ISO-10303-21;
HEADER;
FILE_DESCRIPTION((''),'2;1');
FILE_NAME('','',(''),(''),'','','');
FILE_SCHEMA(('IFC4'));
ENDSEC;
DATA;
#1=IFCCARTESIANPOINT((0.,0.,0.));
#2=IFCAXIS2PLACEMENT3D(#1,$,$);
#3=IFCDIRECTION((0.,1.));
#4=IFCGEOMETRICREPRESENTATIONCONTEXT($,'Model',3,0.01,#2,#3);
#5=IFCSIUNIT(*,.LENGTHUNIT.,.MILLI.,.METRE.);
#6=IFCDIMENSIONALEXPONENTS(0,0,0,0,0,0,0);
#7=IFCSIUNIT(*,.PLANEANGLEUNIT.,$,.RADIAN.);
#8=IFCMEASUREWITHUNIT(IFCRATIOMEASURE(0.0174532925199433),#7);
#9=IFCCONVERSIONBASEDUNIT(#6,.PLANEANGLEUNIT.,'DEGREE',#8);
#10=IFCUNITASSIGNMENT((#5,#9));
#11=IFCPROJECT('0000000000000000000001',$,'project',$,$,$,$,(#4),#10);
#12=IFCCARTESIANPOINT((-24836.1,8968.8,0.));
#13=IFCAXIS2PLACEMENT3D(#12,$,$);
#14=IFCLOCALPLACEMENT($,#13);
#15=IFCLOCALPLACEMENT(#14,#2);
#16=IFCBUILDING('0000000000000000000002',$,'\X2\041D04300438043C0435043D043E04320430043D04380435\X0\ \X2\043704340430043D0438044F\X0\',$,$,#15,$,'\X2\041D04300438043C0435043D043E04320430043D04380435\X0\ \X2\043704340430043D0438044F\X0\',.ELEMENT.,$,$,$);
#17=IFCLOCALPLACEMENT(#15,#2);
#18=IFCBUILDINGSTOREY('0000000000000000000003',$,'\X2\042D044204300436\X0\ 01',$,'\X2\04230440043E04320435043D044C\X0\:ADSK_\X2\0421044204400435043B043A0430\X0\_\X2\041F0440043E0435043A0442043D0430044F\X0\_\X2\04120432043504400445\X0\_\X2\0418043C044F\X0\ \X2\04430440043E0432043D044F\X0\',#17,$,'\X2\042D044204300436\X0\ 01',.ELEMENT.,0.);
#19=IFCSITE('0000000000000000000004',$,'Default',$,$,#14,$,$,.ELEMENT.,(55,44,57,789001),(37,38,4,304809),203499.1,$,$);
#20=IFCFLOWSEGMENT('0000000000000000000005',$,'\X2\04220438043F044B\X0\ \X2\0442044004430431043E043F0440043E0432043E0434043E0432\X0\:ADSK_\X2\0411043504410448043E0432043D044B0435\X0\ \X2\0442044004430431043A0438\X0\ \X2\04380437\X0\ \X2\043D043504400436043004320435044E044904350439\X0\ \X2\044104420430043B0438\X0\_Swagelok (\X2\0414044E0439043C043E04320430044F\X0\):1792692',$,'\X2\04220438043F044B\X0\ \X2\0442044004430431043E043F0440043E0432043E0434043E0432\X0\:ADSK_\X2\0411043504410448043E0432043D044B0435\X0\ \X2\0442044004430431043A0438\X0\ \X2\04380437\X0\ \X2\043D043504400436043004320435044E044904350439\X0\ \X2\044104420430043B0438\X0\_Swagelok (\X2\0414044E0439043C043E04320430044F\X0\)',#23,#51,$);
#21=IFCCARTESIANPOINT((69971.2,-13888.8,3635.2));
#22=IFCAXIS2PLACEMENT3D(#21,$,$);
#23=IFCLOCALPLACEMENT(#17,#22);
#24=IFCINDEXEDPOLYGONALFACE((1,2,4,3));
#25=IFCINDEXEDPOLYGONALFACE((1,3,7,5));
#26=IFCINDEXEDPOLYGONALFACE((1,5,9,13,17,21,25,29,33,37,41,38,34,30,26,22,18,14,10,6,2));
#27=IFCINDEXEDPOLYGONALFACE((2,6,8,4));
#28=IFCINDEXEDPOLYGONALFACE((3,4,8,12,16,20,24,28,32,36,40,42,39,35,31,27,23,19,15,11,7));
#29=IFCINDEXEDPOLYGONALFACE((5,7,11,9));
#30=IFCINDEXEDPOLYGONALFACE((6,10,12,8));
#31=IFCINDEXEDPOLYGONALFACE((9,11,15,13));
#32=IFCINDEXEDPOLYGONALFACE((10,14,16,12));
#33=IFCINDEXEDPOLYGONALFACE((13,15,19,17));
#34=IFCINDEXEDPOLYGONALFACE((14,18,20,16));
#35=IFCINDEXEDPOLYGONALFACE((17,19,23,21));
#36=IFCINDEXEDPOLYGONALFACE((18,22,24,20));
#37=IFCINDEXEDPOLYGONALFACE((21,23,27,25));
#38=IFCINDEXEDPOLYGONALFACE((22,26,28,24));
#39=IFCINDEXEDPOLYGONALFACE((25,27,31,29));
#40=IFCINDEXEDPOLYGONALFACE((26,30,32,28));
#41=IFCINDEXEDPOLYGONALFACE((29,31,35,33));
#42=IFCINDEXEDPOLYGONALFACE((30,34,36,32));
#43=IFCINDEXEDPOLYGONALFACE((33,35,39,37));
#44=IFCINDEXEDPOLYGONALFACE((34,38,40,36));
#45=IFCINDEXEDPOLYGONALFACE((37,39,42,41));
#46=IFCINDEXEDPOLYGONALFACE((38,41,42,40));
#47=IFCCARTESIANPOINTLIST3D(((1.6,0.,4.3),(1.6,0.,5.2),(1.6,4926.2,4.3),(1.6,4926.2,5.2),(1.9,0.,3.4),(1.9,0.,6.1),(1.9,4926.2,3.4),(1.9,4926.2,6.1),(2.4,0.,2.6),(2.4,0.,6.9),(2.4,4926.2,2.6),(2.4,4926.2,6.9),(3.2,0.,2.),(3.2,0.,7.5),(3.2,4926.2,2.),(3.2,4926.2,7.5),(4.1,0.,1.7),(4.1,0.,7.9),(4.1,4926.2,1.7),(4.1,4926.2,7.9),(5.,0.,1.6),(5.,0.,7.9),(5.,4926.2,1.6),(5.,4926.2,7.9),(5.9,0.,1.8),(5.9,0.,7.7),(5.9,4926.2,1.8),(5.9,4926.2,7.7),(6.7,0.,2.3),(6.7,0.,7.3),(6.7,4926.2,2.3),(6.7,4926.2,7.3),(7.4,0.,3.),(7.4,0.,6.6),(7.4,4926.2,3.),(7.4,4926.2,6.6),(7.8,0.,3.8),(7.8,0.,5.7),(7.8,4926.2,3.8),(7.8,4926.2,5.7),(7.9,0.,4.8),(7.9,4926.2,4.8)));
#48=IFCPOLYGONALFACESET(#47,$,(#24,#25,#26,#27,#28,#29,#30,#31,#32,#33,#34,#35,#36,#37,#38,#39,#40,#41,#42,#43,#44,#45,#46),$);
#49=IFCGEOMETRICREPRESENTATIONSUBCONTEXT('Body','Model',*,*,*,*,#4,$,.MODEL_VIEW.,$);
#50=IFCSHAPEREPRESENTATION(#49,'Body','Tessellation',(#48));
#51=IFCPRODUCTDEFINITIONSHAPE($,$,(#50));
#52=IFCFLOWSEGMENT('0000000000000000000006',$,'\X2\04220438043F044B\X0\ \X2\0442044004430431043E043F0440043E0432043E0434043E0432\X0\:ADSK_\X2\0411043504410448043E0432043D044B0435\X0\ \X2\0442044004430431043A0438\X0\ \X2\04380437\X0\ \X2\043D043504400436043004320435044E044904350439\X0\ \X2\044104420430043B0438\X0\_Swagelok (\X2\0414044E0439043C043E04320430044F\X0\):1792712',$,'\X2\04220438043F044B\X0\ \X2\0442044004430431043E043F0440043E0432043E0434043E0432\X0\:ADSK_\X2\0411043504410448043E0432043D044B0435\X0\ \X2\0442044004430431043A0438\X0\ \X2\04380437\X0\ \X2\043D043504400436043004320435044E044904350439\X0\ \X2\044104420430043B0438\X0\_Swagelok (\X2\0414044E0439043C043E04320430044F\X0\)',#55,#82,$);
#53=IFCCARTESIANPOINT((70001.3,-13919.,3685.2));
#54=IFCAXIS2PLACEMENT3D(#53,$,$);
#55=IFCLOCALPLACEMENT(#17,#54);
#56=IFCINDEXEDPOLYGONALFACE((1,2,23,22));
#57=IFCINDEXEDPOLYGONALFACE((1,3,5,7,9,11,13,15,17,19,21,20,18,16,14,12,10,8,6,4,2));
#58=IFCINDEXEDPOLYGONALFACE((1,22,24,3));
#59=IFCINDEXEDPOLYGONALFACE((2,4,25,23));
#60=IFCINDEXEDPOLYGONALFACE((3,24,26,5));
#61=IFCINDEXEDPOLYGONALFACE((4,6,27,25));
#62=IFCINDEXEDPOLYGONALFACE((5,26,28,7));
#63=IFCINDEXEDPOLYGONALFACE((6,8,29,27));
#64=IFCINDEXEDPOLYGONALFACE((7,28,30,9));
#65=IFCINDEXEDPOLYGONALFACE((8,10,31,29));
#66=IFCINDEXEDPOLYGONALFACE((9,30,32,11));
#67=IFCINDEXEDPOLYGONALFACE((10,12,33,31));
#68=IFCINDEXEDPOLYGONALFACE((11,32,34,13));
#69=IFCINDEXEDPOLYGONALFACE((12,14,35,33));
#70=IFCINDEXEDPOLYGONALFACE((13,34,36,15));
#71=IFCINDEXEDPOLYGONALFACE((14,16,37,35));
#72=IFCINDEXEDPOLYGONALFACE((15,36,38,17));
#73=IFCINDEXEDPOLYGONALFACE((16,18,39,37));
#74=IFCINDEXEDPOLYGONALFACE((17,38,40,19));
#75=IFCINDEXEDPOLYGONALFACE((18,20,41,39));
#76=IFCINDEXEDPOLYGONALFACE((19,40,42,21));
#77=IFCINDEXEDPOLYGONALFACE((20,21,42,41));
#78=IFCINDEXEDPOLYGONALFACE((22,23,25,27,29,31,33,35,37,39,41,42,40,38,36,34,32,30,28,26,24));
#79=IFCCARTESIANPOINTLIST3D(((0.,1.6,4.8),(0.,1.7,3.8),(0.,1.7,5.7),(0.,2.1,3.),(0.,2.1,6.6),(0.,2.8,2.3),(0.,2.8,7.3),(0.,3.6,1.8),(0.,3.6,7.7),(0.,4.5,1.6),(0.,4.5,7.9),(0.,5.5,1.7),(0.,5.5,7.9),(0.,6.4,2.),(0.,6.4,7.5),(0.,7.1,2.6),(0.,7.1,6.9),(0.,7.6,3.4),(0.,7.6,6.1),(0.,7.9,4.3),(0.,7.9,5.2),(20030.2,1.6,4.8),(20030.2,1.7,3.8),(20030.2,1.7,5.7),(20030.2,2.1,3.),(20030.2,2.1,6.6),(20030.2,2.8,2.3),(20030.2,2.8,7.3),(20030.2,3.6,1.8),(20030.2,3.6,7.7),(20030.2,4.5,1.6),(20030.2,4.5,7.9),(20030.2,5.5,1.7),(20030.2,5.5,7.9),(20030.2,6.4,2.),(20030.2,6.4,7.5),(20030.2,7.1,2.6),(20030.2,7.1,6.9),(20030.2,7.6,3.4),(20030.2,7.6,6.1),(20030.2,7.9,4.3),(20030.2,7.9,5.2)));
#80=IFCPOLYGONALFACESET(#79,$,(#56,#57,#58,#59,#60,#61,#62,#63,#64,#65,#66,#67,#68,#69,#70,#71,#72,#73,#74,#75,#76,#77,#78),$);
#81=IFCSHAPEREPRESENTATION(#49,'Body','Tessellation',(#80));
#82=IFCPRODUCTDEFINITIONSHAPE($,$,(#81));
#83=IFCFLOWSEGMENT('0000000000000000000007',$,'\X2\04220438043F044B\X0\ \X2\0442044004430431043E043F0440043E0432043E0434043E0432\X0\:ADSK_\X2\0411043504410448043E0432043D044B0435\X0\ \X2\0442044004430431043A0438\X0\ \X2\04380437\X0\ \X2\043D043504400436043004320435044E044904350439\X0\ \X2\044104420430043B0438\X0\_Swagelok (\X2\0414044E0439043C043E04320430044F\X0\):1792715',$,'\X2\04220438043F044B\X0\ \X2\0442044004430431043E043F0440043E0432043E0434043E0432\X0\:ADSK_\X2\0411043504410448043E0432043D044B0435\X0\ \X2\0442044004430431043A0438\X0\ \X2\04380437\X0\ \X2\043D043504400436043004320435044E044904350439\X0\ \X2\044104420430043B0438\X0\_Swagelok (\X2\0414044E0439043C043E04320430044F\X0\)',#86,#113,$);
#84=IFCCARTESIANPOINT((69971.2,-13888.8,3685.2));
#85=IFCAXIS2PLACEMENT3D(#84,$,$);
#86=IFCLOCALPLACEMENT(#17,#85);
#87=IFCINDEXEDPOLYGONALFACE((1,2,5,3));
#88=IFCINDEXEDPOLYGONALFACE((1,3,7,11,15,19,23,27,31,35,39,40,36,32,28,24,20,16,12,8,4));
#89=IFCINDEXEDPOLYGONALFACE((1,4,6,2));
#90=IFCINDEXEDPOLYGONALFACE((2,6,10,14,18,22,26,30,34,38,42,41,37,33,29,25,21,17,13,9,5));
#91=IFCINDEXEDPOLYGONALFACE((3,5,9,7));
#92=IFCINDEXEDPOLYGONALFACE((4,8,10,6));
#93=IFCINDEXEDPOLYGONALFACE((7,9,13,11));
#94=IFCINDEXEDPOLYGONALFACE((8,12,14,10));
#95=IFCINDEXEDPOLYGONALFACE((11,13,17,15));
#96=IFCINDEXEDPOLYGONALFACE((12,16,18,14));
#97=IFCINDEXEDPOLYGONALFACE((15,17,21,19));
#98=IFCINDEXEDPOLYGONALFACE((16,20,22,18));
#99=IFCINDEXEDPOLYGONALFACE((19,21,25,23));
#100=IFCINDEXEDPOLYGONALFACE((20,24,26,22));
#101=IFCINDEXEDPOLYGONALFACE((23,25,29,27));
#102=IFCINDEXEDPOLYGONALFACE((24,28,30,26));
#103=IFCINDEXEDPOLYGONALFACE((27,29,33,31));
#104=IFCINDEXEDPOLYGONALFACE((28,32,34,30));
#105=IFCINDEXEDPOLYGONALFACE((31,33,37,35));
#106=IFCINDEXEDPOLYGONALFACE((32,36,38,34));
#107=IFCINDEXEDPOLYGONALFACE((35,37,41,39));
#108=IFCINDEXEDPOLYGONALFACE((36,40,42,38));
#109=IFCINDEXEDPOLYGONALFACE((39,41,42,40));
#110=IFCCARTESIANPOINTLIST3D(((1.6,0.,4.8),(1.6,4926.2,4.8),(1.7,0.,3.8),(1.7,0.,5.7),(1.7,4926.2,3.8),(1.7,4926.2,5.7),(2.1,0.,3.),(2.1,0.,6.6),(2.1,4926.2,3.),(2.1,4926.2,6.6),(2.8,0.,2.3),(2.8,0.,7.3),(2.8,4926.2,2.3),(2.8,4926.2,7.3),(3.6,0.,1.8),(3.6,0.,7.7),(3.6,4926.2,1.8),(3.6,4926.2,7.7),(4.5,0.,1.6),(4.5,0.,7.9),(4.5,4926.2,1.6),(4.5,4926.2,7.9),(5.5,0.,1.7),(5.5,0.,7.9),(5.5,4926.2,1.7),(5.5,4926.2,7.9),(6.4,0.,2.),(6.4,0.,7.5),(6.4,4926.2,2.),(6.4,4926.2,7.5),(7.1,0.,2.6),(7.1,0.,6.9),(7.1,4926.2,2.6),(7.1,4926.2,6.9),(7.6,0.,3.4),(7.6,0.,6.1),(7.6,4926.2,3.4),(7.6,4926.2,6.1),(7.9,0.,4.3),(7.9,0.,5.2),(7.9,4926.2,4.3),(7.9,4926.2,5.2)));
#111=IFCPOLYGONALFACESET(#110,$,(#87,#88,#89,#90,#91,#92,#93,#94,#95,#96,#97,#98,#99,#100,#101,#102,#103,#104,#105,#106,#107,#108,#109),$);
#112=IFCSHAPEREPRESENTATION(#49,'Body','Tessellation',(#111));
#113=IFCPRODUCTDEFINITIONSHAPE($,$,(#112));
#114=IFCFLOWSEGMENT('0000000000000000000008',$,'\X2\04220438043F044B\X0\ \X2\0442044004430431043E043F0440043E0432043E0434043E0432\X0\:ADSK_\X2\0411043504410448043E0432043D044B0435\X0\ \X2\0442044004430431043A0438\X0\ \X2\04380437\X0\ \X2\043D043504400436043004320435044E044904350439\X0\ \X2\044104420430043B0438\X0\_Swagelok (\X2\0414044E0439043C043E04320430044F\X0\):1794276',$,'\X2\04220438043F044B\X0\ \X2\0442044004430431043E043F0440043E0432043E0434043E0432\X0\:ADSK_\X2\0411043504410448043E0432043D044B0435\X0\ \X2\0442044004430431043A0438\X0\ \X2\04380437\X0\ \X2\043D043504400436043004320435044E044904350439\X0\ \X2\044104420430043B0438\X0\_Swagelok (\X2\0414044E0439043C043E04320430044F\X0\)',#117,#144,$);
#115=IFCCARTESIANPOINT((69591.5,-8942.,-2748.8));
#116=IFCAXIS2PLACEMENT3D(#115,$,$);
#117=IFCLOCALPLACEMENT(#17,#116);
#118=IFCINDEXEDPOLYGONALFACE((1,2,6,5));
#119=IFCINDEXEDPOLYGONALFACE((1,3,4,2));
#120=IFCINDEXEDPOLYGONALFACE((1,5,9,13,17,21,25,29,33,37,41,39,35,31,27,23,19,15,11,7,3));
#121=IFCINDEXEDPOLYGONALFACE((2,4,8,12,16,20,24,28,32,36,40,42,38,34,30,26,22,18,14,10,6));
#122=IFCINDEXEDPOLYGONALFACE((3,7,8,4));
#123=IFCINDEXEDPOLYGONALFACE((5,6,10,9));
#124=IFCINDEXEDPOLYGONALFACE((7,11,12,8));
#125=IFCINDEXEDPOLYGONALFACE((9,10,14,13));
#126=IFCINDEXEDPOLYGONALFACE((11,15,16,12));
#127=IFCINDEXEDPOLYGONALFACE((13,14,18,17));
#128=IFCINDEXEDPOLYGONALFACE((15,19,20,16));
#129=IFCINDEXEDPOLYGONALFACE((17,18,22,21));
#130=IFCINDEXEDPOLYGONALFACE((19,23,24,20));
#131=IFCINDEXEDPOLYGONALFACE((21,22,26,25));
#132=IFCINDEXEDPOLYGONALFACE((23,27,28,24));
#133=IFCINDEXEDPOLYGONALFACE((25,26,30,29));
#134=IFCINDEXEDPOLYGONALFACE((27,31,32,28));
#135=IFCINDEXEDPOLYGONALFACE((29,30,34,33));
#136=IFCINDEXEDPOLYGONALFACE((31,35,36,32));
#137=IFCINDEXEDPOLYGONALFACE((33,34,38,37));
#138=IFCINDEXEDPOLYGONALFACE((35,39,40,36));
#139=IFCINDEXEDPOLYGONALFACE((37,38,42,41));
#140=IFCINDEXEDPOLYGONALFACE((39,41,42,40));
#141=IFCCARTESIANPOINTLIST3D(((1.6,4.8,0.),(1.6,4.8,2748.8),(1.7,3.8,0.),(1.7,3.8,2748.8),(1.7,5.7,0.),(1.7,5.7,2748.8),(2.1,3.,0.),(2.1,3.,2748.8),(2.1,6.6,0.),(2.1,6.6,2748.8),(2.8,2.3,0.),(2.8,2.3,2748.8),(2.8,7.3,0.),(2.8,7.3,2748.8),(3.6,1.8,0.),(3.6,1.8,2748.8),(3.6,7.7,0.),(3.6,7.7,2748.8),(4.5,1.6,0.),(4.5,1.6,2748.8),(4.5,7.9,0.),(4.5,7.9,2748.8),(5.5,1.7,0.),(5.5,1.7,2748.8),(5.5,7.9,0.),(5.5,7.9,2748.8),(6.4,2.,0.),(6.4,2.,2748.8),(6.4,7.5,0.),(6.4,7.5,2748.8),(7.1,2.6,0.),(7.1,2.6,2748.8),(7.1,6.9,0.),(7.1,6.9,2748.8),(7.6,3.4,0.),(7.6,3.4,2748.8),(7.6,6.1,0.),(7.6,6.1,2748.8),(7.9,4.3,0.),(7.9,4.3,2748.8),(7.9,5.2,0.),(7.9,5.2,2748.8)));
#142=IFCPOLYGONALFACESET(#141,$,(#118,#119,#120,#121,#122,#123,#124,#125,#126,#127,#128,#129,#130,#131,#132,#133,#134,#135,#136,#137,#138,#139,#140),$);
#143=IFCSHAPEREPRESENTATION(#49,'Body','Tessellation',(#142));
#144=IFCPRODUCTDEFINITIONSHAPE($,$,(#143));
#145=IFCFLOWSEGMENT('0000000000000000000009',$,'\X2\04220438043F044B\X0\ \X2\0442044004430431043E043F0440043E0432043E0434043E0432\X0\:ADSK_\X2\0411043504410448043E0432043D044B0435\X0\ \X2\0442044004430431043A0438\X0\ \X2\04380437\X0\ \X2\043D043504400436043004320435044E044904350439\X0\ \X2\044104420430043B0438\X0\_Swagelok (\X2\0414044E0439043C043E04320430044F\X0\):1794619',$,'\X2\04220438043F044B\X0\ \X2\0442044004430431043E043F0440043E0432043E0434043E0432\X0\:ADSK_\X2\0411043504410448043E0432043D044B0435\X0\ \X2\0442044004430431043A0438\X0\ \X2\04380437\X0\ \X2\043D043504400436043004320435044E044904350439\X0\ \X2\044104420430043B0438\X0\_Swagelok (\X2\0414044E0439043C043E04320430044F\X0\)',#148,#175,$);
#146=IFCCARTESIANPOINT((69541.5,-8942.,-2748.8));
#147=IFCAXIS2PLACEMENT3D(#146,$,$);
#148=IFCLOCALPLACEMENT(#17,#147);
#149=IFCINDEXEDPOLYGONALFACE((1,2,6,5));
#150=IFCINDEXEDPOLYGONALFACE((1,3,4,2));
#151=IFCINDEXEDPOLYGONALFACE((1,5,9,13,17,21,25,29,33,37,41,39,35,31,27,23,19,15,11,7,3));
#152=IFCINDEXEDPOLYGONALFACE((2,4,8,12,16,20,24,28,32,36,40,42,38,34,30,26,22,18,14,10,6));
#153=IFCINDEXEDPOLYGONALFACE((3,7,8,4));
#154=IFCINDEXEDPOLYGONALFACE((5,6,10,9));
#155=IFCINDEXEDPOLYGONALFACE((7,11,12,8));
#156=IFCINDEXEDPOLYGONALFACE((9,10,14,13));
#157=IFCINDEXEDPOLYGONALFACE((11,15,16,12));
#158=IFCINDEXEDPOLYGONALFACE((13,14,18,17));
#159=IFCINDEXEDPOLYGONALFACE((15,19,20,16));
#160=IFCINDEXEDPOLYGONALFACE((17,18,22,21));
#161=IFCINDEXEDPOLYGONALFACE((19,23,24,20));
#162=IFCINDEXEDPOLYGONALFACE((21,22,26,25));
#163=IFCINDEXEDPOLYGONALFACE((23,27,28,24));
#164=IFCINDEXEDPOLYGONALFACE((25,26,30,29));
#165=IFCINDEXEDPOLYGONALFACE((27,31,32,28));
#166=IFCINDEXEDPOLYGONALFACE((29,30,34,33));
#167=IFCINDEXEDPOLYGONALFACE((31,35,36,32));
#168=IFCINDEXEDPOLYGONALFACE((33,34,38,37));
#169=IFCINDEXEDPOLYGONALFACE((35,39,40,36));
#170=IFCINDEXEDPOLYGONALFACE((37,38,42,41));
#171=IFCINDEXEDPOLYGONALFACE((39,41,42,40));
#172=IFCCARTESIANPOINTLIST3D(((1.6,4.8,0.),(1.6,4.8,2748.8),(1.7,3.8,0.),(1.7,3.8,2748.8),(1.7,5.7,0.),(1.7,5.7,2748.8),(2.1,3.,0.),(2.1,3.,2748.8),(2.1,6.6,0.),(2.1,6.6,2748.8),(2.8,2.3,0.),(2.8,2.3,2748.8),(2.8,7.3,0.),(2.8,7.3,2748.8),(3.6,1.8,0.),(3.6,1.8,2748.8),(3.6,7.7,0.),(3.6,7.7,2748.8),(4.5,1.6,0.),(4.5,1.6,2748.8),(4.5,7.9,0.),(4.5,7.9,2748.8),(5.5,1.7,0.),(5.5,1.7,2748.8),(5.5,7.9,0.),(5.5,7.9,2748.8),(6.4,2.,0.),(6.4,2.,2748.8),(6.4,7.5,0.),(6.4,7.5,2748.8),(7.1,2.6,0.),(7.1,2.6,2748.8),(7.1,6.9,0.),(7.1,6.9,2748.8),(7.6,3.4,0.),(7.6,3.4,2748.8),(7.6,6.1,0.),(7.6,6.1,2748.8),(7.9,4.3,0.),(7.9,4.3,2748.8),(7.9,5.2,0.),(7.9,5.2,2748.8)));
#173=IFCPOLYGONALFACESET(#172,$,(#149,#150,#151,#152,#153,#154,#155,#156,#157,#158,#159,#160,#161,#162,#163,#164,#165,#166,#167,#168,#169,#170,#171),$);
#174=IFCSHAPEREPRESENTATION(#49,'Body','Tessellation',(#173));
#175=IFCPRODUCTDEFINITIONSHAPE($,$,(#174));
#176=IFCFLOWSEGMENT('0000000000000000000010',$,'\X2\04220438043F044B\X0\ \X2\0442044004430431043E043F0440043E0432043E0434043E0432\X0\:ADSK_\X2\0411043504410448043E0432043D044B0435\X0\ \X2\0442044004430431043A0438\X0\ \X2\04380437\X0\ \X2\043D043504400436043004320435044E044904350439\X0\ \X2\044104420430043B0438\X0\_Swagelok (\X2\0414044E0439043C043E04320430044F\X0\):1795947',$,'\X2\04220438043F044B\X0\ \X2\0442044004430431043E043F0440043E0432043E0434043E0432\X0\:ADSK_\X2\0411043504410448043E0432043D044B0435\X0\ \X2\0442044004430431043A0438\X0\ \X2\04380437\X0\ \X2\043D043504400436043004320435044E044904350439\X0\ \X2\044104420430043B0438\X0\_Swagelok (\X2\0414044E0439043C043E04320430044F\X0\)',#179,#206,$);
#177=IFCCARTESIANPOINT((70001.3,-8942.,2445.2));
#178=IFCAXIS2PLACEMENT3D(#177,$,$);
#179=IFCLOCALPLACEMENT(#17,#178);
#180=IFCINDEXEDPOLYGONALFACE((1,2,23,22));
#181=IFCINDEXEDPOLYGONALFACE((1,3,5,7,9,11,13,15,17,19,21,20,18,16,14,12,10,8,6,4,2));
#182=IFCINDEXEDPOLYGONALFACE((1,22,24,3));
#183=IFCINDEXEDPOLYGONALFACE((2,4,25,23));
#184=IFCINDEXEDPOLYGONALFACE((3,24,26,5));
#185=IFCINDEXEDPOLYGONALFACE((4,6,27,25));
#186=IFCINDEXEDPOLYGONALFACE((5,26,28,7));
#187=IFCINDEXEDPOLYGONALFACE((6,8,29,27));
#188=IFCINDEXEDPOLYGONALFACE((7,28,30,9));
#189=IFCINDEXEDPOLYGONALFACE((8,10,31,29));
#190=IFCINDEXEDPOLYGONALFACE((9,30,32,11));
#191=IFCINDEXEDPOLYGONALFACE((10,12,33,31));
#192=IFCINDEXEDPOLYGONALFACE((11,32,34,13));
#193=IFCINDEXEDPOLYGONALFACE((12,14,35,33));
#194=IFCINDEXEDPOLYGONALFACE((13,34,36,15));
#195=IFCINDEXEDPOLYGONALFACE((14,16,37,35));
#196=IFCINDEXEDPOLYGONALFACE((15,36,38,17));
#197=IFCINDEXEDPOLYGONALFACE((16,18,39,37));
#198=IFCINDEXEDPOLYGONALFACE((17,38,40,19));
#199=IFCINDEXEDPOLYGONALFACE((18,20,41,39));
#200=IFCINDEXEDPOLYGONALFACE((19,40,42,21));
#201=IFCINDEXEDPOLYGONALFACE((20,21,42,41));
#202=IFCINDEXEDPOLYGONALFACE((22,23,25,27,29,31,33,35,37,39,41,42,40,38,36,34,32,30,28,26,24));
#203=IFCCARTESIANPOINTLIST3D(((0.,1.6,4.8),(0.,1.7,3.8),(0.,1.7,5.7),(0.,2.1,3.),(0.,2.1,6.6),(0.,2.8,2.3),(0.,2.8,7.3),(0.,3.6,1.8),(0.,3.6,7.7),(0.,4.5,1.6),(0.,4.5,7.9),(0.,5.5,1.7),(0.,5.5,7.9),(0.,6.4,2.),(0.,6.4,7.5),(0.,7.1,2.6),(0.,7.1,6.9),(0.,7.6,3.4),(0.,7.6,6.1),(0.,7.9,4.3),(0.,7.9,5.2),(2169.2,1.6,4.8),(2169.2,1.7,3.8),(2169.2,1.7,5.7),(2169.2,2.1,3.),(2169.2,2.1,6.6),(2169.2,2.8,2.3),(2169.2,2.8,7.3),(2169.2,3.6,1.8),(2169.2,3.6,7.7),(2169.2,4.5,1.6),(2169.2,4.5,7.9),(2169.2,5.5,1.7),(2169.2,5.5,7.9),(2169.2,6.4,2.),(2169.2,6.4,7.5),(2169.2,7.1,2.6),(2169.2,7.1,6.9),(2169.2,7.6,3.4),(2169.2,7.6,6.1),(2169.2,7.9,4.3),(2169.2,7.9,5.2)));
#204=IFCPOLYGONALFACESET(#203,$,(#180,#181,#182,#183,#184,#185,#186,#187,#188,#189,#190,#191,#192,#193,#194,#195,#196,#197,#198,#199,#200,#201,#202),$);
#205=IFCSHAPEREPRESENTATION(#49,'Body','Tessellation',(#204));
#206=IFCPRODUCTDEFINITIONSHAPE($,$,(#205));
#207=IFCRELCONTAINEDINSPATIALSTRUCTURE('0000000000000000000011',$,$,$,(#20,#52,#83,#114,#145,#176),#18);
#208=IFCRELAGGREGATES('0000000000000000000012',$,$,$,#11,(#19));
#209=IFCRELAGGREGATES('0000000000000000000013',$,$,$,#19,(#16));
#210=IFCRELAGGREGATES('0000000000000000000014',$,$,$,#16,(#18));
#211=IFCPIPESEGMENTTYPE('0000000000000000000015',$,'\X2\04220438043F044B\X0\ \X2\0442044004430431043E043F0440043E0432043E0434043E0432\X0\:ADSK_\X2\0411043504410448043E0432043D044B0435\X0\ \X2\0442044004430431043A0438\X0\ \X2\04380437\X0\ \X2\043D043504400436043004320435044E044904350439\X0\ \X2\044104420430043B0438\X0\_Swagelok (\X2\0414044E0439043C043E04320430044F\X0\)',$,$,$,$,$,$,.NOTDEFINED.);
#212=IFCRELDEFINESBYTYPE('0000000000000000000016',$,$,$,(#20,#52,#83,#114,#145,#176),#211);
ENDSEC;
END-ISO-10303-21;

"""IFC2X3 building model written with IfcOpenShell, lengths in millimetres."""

from ifc_helpers import new_model, entity, si_unit, converted_unit, direction, frame, origin, origin_2d_with_axis, place, context, subcontext, project, spatial, circle, extrude, type_object, element, save


model = new_model("IFC2X3")

# Units and contexts
model_context = context("Model", 3, precision=0.01, world=origin(), true_north=direction((0.0, 1.0)))
body_context = subcontext(model_context, "Body", "Model", "MODEL_VIEW")
ifc_project = project(units=[si_unit("LENGTHUNIT", "METRE", prefix="MILLI"), converted_unit("PLANEANGLEUNIT", "DEGREE", entity("IfcRatioMeasure", 0.0174532925199433), si_unit("PLANEANGLEUNIT", "RADIAN"), dimensions=[0, 0, 0, 0, 0, 0, 0])], contexts=[model_context])

# Site, building, storey
site_placement = place(None, frame((-24836.1, 8968.8, 0.0)))
site = spatial("IfcSite", under=ifc_project, at=site_placement, Name="Default", CompositionType="ELEMENT", RefLatitude=(55, 44, 57, 789001), RefLongitude=(37, 38, 4, 304809), RefElevation=203499.1)
building_placement = place(site_placement, origin())
building = spatial("IfcBuilding", under=site, at=building_placement, Name="Наименование здания", LongName="Наименование здания", CompositionType="ELEMENT")
storey_placement = place(building_placement, origin())
storey = spatial("IfcBuildingStorey", under=building, at=storey_placement, Name="Этаж 01", ObjectType="Уровень:ADSK_Стрелка_Проектная_Вверх_Имя уровня", LongName="Этаж 01", CompositionType="ELEMENT", Elevation=0.0)

# Flow segments
pipe_segment_type_1 = type_object("IfcPipeSegmentType", Name="Типы трубопроводов:ADSK_Бесшовные трубки из нержавеющей стали_Swagelok (Дюймовая)", PredefinedType="NOTDEFINED")
flow_segment_1_placement = place(storey_placement, frame((69971.2, -13888.8, 3635.2)))
element("IfcFlowSegment", 1, at=flow_segment_1_placement, inside=storey, type_object=pipe_segment_type_1, Name="Типы трубопроводов:ADSK_Бесшовные трубки из нержавеющей стали_Swagelok (Дюймовая):1792692", ObjectType="Типы трубопроводов:ADSK_Бесшовные трубки из нержавеющей стали_Swagelok (Дюймовая)", context=body_context, shape_type="SweptSolid", body=[
    extrude(circle(Radius=3.2, at=origin_2d_with_axis()), frame((4.8, 0.0, 4.8), z_axis=(0.0, 1.0, 0.0), x_axis=(1.0, 0.0, 0.0)), (0.0, 0.0, 1.0), 4926.2),
])
flow_segment_2_placement = place(storey_placement, frame((70001.3, -13919.0, 3685.2)))
element("IfcFlowSegment", 2, at=flow_segment_2_placement, inside=storey, type_object=pipe_segment_type_1, Name="Типы трубопроводов:ADSK_Бесшовные трубки из нержавеющей стали_Swagelok (Дюймовая):1792712", ObjectType="Типы трубопроводов:ADSK_Бесшовные трубки из нержавеющей стали_Swagelok (Дюймовая)", context=body_context, shape_type="SweptSolid", body=[
    extrude(circle(Radius=3.2, at=origin_2d_with_axis()), frame((0.0, 4.8, 4.8), z_axis=(1.0, 0.0, 0.0), x_axis=(0.0, -1.0, 0.0)), (0.0, 0.0, 1.0), 20030.2),
])
flow_segment_3_placement = place(storey_placement, frame((69971.2, -13888.8, 3685.2)))
element("IfcFlowSegment", 3, at=flow_segment_3_placement, inside=storey, type_object=pipe_segment_type_1, Name="Типы трубопроводов:ADSK_Бесшовные трубки из нержавеющей стали_Swagelok (Дюймовая):1792715", ObjectType="Типы трубопроводов:ADSK_Бесшовные трубки из нержавеющей стали_Swagelok (Дюймовая)", context=body_context, shape_type="SweptSolid", body=[
    extrude(circle(Radius=3.2, at=origin_2d_with_axis()), frame((4.8, 0.0, 4.8), z_axis=(0.0, 1.0, 0.0), x_axis=(-1.0, 0.0, 0.0)), (0.0, 0.0, 1.0), 4926.2),
])
flow_segment_4_placement = place(storey_placement, frame((69591.5, -8942.0, -2748.8)))
element("IfcFlowSegment", 4, at=flow_segment_4_placement, inside=storey, type_object=pipe_segment_type_1, Name="Типы трубопроводов:ADSK_Бесшовные трубки из нержавеющей стали_Swagelok (Дюймовая):1794276", ObjectType="Типы трубопроводов:ADSK_Бесшовные трубки из нержавеющей стали_Swagelok (Дюймовая)", context=body_context, shape_type="SweptSolid", body=[
    extrude(circle(Radius=3.2, at=origin_2d_with_axis()), frame((4.8, 4.8, 0.0), z_axis=(0.0, 0.0, 1.0), x_axis=(-1.0, 0.0, 0.0)), (0.0, 0.0, 1.0), 2748.8),
])
flow_segment_5_placement = place(storey_placement, frame((69541.5, -8942.0, -2748.8)))
element("IfcFlowSegment", 5, at=flow_segment_5_placement, inside=storey, type_object=pipe_segment_type_1, Name="Типы трубопроводов:ADSK_Бесшовные трубки из нержавеющей стали_Swagelok (Дюймовая):1794619", ObjectType="Типы трубопроводов:ADSK_Бесшовные трубки из нержавеющей стали_Swagelok (Дюймовая)", context=body_context, shape_type="SweptSolid", body=[
    extrude(circle(Radius=3.2, at=origin_2d_with_axis()), frame((4.8, 4.8, 0.0), z_axis=(0.0, 0.0, 1.0), x_axis=(-1.0, 0.0, 0.0)), (0.0, 0.0, 1.0), 2748.8),
])
flow_segment_6_placement = place(storey_placement, frame((70001.3, -8942.0, 2445.2)))
element("IfcFlowSegment", 6, at=flow_segment_6_placement, inside=storey, type_object=pipe_segment_type_1, Name="Типы трубопроводов:ADSK_Бесшовные трубки из нержавеющей стали_Swagelok (Дюймовая):1795947", ObjectType="Типы трубопроводов:ADSK_Бесшовные трубки из нержавеющей стали_Swagelok (Дюймовая)", context=body_context, shape_type="SweptSolid", body=[
    extrude(circle(Radius=3.2, at=origin_2d_with_axis()), frame((0.0, 4.8, 4.8), z_axis=(1.0, 0.0, 0.0), x_axis=(0.0, -1.0, 0.0)), (0.0, 0.0, 1.0), 2169.2),
])

save(model, "model.ifc")
